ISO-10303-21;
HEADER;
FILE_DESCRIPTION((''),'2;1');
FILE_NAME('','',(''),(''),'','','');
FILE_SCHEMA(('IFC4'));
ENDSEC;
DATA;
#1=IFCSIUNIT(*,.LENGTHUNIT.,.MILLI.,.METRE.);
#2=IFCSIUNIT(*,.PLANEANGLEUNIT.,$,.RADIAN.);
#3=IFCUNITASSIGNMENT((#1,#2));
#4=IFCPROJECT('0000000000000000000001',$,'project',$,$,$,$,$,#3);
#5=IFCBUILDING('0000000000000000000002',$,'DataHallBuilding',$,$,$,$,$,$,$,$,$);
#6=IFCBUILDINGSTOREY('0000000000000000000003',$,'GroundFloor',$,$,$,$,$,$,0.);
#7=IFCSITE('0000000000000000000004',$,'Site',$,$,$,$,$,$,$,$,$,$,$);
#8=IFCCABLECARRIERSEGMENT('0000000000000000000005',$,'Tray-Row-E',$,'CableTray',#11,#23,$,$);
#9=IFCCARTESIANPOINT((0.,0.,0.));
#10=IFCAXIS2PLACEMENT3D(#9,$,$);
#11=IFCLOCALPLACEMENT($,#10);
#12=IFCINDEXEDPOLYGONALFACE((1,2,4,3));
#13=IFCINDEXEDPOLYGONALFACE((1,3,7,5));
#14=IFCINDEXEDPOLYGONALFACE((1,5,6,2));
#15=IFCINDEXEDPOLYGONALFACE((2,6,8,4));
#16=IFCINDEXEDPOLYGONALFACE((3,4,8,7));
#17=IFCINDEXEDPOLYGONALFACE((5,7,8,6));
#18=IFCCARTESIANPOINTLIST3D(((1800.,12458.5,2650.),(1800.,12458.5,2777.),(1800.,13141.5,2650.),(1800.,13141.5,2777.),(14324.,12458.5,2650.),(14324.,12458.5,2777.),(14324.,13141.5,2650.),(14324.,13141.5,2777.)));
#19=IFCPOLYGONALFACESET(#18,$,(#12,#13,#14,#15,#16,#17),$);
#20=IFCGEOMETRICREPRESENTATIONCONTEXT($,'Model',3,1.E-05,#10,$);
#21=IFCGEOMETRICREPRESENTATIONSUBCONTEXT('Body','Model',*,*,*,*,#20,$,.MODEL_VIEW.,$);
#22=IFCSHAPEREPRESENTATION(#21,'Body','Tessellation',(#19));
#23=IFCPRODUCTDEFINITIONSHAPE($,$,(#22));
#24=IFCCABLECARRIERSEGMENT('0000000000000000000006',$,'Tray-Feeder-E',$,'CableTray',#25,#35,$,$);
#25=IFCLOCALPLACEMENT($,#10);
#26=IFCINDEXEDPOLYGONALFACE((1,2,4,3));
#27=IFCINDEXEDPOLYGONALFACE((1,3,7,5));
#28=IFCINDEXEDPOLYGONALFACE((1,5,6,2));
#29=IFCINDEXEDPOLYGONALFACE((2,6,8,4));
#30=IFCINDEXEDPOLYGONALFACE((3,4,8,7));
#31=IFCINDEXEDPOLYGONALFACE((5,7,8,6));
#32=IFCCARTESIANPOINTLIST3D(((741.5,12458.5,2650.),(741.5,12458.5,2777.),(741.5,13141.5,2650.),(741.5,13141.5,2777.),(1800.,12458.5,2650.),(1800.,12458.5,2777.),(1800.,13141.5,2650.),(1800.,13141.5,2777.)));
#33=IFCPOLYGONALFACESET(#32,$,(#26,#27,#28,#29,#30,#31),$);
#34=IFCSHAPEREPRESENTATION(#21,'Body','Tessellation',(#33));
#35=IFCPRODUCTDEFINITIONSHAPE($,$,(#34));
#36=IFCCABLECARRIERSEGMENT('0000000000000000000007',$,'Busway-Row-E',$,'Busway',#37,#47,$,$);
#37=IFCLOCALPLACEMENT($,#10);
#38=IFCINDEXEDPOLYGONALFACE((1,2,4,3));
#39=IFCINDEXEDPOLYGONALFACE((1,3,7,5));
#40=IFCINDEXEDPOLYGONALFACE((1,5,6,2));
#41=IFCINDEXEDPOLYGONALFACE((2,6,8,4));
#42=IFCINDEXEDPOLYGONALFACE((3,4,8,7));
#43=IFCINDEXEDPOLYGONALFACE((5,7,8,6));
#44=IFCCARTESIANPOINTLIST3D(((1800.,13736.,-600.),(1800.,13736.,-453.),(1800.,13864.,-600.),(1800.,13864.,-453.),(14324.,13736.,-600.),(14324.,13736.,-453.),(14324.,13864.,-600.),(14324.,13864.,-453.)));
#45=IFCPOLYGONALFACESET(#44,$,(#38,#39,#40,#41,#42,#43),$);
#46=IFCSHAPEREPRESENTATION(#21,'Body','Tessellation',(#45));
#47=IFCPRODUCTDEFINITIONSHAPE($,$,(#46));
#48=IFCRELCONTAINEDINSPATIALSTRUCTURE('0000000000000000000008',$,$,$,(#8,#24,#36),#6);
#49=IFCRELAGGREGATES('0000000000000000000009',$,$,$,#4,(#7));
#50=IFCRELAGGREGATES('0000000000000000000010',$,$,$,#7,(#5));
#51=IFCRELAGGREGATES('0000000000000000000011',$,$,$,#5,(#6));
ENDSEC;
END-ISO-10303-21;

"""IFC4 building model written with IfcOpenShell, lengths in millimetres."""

from ifc_helpers import new_model, si_unit, frame, origin, place, context, subcontext, project, spatial, rectangle, extrude, element, save


model = new_model("IFC4")

# Units and contexts
model_context = context("Model", 3, precision=1e-05, world=origin())
body_context = subcontext(model_context, "Body", "Model", "MODEL_VIEW")
ifc_project = project(units=[si_unit("LENGTHUNIT", "METRE", prefix="MILLI"), si_unit("PLANEANGLEUNIT", "RADIAN")])

# Site, building, storey
site = spatial("IfcSite", under=ifc_project, Name="Site")
building = spatial("IfcBuilding", under=site, Name="DataHallBuilding")
storey = spatial("IfcBuildingStorey", under=building, Name="GroundFloor", Elevation=0.0)

# Cable carrier segments
cable_carrier_segment_1_placement = place(None, origin())
element("IfcCableCarrierSegment", 1, at=cable_carrier_segment_1_placement, inside=storey, Name="Tray-Row-E", ObjectType="CableTray", context=body_context, shape_type="SweptSolid", body=[
    extrude(rectangle(XDim=12524.0, YDim=683.0), frame((8062.0, 12800.0, 2650.0), z_axis=(0.0, 0.0, 1.0), x_axis=(1.0, 0.0, 0.0)), (0.0, 0.0, 1.0), 127.0),
])
cable_carrier_segment_2_placement = place(None, origin())
element("IfcCableCarrierSegment", 2, at=cable_carrier_segment_2_placement, inside=storey, Name="Tray-Feeder-E", ObjectType="CableTray", context=body_context, shape_type="SweptSolid", body=[
    extrude(rectangle(XDim=1058.5, YDim=683.0), frame((1270.8, 12800.0, 2650.0), z_axis=(0.0, 0.0, 1.0), x_axis=(1.0, 0.0, 0.0)), (0.0, 0.0, 1.0), 127.0),
])
cable_carrier_segment_3_placement = place(None, origin())
element("IfcCableCarrierSegment", 3, at=cable_carrier_segment_3_placement, inside=storey, Name="Busway-Row-E", ObjectType="Busway", context=body_context, shape_type="SweptSolid", body=[
    extrude(rectangle(XDim=12524.0, YDim=128.0), frame((8062.0, 13800.0, -600.0), z_axis=(0.0, 0.0, 1.0), x_axis=(1.0, 0.0, 0.0)), (0.0, 0.0, 1.0), 147.0),
])

save(model, "model.ifc")
